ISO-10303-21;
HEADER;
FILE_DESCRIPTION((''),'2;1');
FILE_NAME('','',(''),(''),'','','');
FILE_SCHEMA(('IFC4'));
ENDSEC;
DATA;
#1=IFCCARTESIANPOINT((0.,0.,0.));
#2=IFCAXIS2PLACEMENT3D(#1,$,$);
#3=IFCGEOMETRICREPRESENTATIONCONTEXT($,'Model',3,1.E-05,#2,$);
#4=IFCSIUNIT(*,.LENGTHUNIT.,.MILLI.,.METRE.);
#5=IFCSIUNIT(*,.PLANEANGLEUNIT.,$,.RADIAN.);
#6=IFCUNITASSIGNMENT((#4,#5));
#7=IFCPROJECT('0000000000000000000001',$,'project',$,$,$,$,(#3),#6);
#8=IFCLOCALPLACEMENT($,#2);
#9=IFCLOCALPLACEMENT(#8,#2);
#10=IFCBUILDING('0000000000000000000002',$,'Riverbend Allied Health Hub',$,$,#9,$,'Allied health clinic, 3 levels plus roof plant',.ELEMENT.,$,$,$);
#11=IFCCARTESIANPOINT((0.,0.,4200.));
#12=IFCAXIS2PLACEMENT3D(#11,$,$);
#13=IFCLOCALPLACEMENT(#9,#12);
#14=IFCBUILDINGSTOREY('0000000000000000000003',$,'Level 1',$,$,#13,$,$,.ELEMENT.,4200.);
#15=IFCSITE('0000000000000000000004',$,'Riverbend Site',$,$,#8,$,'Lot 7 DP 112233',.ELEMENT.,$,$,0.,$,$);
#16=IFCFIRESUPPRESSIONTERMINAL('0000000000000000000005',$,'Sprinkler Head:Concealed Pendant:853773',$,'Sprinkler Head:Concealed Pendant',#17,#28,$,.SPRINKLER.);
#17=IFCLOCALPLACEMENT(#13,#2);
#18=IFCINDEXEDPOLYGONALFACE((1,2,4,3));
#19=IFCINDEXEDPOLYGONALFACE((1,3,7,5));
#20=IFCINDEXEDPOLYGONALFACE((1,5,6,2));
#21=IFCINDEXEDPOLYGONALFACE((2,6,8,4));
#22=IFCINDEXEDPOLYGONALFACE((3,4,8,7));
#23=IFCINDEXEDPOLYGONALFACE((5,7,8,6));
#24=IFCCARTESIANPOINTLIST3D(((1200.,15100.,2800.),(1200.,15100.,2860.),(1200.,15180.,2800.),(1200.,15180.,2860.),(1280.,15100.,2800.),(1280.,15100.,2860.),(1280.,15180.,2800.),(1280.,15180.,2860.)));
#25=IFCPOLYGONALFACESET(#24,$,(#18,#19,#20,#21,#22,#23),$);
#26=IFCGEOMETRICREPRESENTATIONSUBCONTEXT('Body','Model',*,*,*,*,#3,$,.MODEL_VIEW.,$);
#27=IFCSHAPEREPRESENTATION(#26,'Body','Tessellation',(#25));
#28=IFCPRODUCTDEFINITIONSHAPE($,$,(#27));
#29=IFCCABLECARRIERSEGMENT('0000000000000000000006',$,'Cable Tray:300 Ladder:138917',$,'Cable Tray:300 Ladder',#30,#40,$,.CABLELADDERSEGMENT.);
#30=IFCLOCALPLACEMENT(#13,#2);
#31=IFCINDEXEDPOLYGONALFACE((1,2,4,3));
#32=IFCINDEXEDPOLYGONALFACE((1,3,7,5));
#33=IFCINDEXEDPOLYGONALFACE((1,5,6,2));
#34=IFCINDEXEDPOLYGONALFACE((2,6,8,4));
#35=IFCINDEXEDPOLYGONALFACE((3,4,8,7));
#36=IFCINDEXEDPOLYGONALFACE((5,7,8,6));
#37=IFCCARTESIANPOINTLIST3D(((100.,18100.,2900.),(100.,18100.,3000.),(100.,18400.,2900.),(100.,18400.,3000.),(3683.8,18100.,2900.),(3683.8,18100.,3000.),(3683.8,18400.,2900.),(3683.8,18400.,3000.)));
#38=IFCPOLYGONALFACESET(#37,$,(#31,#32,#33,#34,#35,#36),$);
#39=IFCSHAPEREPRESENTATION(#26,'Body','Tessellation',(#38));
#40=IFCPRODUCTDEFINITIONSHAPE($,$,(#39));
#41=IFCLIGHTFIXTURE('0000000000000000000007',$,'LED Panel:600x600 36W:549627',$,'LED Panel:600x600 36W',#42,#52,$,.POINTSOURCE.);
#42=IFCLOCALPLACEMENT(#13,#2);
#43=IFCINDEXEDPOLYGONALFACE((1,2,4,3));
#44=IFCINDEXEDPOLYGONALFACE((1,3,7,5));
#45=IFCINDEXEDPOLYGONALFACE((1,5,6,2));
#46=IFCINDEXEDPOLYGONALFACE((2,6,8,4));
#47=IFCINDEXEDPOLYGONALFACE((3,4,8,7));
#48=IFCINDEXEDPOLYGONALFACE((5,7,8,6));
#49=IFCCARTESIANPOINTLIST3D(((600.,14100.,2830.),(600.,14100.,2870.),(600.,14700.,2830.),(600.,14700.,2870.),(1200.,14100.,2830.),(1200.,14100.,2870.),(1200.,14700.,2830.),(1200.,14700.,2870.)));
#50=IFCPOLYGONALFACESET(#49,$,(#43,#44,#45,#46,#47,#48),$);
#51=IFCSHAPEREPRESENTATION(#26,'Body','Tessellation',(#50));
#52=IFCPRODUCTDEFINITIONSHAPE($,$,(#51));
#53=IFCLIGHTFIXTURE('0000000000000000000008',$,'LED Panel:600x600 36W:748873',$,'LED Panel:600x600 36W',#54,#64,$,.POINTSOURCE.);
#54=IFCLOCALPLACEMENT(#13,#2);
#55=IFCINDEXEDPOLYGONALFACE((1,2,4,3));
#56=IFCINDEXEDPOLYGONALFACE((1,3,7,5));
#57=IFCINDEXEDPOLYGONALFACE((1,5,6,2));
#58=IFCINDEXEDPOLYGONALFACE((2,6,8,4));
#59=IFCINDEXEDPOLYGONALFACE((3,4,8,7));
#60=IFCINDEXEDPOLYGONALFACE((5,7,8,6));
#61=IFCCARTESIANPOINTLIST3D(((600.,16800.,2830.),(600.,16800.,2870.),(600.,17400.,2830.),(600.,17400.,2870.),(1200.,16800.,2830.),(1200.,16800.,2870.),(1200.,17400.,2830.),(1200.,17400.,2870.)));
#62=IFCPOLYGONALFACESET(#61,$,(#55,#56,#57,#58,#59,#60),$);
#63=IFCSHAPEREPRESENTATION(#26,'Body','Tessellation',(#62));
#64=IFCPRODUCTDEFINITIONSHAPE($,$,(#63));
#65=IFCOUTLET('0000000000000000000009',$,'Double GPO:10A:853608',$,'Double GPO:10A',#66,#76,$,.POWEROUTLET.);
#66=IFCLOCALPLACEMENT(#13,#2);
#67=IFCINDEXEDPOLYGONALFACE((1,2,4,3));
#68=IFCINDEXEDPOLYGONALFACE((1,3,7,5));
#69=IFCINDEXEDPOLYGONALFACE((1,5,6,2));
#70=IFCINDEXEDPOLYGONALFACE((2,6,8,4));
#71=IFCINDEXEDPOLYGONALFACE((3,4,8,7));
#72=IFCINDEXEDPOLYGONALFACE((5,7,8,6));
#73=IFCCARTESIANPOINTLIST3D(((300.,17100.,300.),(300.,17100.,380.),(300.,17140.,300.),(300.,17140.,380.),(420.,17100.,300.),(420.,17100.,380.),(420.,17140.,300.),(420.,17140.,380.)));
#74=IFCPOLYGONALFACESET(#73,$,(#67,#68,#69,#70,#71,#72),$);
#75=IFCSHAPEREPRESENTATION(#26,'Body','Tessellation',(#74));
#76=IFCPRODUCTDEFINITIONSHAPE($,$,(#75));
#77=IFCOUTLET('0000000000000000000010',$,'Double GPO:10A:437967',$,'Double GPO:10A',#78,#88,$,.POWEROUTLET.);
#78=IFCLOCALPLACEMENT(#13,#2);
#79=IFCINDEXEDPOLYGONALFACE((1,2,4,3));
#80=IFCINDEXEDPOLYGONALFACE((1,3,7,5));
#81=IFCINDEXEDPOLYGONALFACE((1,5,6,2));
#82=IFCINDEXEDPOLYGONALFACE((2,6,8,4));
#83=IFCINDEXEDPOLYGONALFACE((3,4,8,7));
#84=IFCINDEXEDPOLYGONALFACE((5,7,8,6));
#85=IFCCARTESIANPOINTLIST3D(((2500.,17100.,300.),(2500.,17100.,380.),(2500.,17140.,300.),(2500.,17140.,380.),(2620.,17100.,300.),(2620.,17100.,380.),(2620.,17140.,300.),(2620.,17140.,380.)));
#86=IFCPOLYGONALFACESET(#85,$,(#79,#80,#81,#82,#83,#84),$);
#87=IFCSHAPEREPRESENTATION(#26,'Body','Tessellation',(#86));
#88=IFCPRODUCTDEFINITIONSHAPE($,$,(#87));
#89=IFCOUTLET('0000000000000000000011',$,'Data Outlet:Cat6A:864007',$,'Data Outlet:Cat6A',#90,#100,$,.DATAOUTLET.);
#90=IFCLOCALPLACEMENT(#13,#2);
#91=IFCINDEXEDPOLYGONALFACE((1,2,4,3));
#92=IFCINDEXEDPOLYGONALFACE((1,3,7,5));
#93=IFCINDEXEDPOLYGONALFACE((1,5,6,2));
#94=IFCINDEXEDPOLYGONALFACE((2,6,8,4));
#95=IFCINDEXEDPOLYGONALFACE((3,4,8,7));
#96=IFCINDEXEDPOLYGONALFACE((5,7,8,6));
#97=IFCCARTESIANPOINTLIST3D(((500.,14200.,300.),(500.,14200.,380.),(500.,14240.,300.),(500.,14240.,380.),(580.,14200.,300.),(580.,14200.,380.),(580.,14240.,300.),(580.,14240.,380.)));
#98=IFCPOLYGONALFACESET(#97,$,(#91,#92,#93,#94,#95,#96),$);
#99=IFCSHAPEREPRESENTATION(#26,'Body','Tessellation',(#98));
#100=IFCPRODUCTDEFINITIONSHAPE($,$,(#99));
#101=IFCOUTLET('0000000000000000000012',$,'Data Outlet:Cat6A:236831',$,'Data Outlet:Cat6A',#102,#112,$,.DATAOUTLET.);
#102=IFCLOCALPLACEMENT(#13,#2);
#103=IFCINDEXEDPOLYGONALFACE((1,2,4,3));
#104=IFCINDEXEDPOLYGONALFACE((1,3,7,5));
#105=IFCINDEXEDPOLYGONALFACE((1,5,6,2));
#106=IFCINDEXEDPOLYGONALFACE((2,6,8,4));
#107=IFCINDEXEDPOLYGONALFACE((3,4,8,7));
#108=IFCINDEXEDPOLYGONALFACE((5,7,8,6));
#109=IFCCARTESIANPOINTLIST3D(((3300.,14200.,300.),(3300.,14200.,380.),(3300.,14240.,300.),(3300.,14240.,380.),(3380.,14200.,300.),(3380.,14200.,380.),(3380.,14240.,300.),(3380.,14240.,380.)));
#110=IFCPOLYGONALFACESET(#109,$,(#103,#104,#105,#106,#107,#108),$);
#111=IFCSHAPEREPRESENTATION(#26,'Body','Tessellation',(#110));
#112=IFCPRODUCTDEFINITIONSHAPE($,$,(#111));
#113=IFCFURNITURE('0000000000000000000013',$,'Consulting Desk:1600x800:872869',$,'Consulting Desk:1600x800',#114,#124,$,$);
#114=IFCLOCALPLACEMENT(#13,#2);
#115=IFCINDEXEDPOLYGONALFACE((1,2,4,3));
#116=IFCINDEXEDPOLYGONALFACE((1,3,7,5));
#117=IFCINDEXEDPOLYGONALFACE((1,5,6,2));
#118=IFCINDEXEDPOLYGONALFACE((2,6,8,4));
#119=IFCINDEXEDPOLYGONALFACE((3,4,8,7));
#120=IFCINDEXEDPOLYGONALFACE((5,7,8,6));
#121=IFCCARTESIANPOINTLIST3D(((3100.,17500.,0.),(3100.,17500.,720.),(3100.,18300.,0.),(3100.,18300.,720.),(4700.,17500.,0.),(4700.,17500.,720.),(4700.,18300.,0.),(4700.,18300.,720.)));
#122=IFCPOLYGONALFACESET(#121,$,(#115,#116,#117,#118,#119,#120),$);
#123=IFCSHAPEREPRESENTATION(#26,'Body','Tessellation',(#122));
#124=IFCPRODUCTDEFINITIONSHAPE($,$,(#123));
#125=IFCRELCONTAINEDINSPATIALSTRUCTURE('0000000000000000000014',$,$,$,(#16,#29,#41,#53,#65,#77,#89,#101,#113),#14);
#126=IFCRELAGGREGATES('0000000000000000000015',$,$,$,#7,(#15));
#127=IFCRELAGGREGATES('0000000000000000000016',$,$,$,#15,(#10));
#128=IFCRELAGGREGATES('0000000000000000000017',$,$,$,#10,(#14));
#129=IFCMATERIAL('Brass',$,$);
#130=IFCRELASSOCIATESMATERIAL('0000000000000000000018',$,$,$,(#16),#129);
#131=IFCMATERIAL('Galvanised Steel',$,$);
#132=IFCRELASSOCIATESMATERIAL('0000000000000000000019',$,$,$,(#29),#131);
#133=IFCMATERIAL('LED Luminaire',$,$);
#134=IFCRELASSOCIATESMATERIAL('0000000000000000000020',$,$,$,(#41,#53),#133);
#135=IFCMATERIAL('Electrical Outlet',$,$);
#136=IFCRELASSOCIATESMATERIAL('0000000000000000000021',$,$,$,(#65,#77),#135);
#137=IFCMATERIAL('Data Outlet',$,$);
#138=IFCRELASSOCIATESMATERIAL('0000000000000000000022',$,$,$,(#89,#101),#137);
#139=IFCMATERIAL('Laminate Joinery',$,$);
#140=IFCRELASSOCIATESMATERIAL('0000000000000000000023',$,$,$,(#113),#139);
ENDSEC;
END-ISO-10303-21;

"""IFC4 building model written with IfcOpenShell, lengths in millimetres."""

from ifc_helpers import new_model, si_unit, frame, frame_2d, origin, place, context, subcontext, project, spatial, rectangle, extrude, material, element, save


model = new_model("IFC4")

# Units and contexts
model_context = context("Model", 3, precision=1e-05, world=origin())
body_context = subcontext(model_context, "Body", "Model", "MODEL_VIEW")
ifc_project = project(units=[si_unit("LENGTHUNIT", "METRE", prefix="MILLI"), si_unit("PLANEANGLEUNIT", "RADIAN")], contexts=[model_context])

# Site, building, storey
site_placement = place(None, origin())
site = spatial("IfcSite", under=ifc_project, at=site_placement, Name="Riverbend Site", LongName="Lot 7 DP 112233", CompositionType="ELEMENT", RefElevation=0.0)
building_placement = place(site_placement, origin())
building = spatial("IfcBuilding", under=site, at=building_placement, Name="Riverbend Allied Health Hub", LongName="Allied health clinic, 3 levels plus roof plant", CompositionType="ELEMENT")
storey_placement = place(building_placement, frame((0.0, 0.0, 4200.0)))
storey = spatial("IfcBuildingStorey", under=building, at=storey_placement, Name="Level 1", CompositionType="ELEMENT", Elevation=4200.0)

# Shared definitions
ifc_material_1 = material(Name="Galvanised Steel")

# Fire suppression terminal
ifc_material_2 = material(Name="Brass")
fire_suppression_terminal_placement = place(storey_placement, frame((1200.0, 15100.0, 2800.0)))
element("IfcFireSuppressionTerminal", 1, at=fire_suppression_terminal_placement, inside=storey, material=ifc_material_2, Name="Sprinkler Head:Concealed Pendant:853773", ObjectType="Sprinkler Head:Concealed Pendant", PredefinedType="SPRINKLER", context=body_context, shape_type="SweptSolid", body=[
    extrude(rectangle(XDim=80.0, YDim=80.0, at=frame_2d((40.0, 40.0))), origin(), (0.0, 0.0, 1.0), 60.0),
])

# Cable carrier segment
cable_carrier_segment_placement = place(storey_placement, frame((100.0, 18100.0, 2900.0)))
element("IfcCableCarrierSegment", 2, at=cable_carrier_segment_placement, inside=storey, material=ifc_material_1, Name="Cable Tray:300 Ladder:138917", ObjectType="Cable Tray:300 Ladder", PredefinedType="CABLELADDERSEGMENT", context=body_context, shape_type="SweptSolid", body=[
    extrude(rectangle(XDim=3583.8, YDim=300.0, at=frame_2d((1791.9, 150.0))), origin(), (0.0, 0.0, 1.0), 100.0),
])

# Light fixtures
ifc_material_3 = material(Name="LED Luminaire")
for number, where, name in (
    (3, (600.0, 14100.0, 2830.0), "LED Panel:600x600 36W:549627"),
    (4, (600.0, 16800.0, 2830.0), "LED Panel:600x600 36W:748873"),
):
    element("IfcLightFixture", number, at=place(storey_placement, frame(where)), inside=storey, material=ifc_material_3, Name=name, ObjectType="LED Panel:600x600 36W", PredefinedType="POINTSOURCE", context=body_context, shape_type="SweptSolid", body=[
        extrude(rectangle(XDim=600.0, YDim=600.0, at=frame_2d((300.0, 300.0))), origin(), (0.0, 0.0, 1.0), 40.0),
    ])

# Outlets
ifc_material_4 = material(Name="Electrical Outlet")
for number, where, name in (
    (5, (300.0, 17100.0, 300.0), "Double GPO:10A:853608"),
    (6, (2500.0, 17100.0, 300.0), "Double GPO:10A:437967"),
):
    element("IfcOutlet", number, at=place(storey_placement, frame(where)), inside=storey, material=ifc_material_4, Name=name, ObjectType="Double GPO:10A", PredefinedType="POWEROUTLET", context=body_context, shape_type="SweptSolid", body=[
        extrude(rectangle(XDim=120.0, YDim=40.0, at=frame_2d((60.0, 20.0))), origin(), (0.0, 0.0, 1.0), 80.0),
    ])
ifc_material_5 = material(Name="Data Outlet")
for number, where, name in (
    (7, (500.0, 14200.0, 300.0), "Data Outlet:Cat6A:864007"),
    (8, (3300.0, 14200.0, 300.0), "Data Outlet:Cat6A:236831"),
):
    element("IfcOutlet", number, at=place(storey_placement, frame(where)), inside=storey, material=ifc_material_5, Name=name, ObjectType="Data Outlet:Cat6A", PredefinedType="DATAOUTLET", context=body_context, shape_type="SweptSolid", body=[
        extrude(rectangle(XDim=80.0, YDim=40.0, at=frame_2d((40.0, 20.0))), origin(), (0.0, 0.0, 1.0), 80.0),
    ])

# Furniture
ifc_material_6 = material(Name="Laminate Joinery")
furniture_placement = place(storey_placement, frame((3100.0, 17500.0, 0.0)))
element("IfcFurniture", 9, at=furniture_placement, inside=storey, material=ifc_material_6, Name="Consulting Desk:1600x800:872869", ObjectType="Consulting Desk:1600x800", context=body_context, shape_type="SweptSolid", body=[
    extrude(rectangle(XDim=1600.0, YDim=800.0, at=frame_2d((800.0, 400.0))), origin(), (0.0, 0.0, 1.0), 720.0),
])

save(model, "model.ifc")
